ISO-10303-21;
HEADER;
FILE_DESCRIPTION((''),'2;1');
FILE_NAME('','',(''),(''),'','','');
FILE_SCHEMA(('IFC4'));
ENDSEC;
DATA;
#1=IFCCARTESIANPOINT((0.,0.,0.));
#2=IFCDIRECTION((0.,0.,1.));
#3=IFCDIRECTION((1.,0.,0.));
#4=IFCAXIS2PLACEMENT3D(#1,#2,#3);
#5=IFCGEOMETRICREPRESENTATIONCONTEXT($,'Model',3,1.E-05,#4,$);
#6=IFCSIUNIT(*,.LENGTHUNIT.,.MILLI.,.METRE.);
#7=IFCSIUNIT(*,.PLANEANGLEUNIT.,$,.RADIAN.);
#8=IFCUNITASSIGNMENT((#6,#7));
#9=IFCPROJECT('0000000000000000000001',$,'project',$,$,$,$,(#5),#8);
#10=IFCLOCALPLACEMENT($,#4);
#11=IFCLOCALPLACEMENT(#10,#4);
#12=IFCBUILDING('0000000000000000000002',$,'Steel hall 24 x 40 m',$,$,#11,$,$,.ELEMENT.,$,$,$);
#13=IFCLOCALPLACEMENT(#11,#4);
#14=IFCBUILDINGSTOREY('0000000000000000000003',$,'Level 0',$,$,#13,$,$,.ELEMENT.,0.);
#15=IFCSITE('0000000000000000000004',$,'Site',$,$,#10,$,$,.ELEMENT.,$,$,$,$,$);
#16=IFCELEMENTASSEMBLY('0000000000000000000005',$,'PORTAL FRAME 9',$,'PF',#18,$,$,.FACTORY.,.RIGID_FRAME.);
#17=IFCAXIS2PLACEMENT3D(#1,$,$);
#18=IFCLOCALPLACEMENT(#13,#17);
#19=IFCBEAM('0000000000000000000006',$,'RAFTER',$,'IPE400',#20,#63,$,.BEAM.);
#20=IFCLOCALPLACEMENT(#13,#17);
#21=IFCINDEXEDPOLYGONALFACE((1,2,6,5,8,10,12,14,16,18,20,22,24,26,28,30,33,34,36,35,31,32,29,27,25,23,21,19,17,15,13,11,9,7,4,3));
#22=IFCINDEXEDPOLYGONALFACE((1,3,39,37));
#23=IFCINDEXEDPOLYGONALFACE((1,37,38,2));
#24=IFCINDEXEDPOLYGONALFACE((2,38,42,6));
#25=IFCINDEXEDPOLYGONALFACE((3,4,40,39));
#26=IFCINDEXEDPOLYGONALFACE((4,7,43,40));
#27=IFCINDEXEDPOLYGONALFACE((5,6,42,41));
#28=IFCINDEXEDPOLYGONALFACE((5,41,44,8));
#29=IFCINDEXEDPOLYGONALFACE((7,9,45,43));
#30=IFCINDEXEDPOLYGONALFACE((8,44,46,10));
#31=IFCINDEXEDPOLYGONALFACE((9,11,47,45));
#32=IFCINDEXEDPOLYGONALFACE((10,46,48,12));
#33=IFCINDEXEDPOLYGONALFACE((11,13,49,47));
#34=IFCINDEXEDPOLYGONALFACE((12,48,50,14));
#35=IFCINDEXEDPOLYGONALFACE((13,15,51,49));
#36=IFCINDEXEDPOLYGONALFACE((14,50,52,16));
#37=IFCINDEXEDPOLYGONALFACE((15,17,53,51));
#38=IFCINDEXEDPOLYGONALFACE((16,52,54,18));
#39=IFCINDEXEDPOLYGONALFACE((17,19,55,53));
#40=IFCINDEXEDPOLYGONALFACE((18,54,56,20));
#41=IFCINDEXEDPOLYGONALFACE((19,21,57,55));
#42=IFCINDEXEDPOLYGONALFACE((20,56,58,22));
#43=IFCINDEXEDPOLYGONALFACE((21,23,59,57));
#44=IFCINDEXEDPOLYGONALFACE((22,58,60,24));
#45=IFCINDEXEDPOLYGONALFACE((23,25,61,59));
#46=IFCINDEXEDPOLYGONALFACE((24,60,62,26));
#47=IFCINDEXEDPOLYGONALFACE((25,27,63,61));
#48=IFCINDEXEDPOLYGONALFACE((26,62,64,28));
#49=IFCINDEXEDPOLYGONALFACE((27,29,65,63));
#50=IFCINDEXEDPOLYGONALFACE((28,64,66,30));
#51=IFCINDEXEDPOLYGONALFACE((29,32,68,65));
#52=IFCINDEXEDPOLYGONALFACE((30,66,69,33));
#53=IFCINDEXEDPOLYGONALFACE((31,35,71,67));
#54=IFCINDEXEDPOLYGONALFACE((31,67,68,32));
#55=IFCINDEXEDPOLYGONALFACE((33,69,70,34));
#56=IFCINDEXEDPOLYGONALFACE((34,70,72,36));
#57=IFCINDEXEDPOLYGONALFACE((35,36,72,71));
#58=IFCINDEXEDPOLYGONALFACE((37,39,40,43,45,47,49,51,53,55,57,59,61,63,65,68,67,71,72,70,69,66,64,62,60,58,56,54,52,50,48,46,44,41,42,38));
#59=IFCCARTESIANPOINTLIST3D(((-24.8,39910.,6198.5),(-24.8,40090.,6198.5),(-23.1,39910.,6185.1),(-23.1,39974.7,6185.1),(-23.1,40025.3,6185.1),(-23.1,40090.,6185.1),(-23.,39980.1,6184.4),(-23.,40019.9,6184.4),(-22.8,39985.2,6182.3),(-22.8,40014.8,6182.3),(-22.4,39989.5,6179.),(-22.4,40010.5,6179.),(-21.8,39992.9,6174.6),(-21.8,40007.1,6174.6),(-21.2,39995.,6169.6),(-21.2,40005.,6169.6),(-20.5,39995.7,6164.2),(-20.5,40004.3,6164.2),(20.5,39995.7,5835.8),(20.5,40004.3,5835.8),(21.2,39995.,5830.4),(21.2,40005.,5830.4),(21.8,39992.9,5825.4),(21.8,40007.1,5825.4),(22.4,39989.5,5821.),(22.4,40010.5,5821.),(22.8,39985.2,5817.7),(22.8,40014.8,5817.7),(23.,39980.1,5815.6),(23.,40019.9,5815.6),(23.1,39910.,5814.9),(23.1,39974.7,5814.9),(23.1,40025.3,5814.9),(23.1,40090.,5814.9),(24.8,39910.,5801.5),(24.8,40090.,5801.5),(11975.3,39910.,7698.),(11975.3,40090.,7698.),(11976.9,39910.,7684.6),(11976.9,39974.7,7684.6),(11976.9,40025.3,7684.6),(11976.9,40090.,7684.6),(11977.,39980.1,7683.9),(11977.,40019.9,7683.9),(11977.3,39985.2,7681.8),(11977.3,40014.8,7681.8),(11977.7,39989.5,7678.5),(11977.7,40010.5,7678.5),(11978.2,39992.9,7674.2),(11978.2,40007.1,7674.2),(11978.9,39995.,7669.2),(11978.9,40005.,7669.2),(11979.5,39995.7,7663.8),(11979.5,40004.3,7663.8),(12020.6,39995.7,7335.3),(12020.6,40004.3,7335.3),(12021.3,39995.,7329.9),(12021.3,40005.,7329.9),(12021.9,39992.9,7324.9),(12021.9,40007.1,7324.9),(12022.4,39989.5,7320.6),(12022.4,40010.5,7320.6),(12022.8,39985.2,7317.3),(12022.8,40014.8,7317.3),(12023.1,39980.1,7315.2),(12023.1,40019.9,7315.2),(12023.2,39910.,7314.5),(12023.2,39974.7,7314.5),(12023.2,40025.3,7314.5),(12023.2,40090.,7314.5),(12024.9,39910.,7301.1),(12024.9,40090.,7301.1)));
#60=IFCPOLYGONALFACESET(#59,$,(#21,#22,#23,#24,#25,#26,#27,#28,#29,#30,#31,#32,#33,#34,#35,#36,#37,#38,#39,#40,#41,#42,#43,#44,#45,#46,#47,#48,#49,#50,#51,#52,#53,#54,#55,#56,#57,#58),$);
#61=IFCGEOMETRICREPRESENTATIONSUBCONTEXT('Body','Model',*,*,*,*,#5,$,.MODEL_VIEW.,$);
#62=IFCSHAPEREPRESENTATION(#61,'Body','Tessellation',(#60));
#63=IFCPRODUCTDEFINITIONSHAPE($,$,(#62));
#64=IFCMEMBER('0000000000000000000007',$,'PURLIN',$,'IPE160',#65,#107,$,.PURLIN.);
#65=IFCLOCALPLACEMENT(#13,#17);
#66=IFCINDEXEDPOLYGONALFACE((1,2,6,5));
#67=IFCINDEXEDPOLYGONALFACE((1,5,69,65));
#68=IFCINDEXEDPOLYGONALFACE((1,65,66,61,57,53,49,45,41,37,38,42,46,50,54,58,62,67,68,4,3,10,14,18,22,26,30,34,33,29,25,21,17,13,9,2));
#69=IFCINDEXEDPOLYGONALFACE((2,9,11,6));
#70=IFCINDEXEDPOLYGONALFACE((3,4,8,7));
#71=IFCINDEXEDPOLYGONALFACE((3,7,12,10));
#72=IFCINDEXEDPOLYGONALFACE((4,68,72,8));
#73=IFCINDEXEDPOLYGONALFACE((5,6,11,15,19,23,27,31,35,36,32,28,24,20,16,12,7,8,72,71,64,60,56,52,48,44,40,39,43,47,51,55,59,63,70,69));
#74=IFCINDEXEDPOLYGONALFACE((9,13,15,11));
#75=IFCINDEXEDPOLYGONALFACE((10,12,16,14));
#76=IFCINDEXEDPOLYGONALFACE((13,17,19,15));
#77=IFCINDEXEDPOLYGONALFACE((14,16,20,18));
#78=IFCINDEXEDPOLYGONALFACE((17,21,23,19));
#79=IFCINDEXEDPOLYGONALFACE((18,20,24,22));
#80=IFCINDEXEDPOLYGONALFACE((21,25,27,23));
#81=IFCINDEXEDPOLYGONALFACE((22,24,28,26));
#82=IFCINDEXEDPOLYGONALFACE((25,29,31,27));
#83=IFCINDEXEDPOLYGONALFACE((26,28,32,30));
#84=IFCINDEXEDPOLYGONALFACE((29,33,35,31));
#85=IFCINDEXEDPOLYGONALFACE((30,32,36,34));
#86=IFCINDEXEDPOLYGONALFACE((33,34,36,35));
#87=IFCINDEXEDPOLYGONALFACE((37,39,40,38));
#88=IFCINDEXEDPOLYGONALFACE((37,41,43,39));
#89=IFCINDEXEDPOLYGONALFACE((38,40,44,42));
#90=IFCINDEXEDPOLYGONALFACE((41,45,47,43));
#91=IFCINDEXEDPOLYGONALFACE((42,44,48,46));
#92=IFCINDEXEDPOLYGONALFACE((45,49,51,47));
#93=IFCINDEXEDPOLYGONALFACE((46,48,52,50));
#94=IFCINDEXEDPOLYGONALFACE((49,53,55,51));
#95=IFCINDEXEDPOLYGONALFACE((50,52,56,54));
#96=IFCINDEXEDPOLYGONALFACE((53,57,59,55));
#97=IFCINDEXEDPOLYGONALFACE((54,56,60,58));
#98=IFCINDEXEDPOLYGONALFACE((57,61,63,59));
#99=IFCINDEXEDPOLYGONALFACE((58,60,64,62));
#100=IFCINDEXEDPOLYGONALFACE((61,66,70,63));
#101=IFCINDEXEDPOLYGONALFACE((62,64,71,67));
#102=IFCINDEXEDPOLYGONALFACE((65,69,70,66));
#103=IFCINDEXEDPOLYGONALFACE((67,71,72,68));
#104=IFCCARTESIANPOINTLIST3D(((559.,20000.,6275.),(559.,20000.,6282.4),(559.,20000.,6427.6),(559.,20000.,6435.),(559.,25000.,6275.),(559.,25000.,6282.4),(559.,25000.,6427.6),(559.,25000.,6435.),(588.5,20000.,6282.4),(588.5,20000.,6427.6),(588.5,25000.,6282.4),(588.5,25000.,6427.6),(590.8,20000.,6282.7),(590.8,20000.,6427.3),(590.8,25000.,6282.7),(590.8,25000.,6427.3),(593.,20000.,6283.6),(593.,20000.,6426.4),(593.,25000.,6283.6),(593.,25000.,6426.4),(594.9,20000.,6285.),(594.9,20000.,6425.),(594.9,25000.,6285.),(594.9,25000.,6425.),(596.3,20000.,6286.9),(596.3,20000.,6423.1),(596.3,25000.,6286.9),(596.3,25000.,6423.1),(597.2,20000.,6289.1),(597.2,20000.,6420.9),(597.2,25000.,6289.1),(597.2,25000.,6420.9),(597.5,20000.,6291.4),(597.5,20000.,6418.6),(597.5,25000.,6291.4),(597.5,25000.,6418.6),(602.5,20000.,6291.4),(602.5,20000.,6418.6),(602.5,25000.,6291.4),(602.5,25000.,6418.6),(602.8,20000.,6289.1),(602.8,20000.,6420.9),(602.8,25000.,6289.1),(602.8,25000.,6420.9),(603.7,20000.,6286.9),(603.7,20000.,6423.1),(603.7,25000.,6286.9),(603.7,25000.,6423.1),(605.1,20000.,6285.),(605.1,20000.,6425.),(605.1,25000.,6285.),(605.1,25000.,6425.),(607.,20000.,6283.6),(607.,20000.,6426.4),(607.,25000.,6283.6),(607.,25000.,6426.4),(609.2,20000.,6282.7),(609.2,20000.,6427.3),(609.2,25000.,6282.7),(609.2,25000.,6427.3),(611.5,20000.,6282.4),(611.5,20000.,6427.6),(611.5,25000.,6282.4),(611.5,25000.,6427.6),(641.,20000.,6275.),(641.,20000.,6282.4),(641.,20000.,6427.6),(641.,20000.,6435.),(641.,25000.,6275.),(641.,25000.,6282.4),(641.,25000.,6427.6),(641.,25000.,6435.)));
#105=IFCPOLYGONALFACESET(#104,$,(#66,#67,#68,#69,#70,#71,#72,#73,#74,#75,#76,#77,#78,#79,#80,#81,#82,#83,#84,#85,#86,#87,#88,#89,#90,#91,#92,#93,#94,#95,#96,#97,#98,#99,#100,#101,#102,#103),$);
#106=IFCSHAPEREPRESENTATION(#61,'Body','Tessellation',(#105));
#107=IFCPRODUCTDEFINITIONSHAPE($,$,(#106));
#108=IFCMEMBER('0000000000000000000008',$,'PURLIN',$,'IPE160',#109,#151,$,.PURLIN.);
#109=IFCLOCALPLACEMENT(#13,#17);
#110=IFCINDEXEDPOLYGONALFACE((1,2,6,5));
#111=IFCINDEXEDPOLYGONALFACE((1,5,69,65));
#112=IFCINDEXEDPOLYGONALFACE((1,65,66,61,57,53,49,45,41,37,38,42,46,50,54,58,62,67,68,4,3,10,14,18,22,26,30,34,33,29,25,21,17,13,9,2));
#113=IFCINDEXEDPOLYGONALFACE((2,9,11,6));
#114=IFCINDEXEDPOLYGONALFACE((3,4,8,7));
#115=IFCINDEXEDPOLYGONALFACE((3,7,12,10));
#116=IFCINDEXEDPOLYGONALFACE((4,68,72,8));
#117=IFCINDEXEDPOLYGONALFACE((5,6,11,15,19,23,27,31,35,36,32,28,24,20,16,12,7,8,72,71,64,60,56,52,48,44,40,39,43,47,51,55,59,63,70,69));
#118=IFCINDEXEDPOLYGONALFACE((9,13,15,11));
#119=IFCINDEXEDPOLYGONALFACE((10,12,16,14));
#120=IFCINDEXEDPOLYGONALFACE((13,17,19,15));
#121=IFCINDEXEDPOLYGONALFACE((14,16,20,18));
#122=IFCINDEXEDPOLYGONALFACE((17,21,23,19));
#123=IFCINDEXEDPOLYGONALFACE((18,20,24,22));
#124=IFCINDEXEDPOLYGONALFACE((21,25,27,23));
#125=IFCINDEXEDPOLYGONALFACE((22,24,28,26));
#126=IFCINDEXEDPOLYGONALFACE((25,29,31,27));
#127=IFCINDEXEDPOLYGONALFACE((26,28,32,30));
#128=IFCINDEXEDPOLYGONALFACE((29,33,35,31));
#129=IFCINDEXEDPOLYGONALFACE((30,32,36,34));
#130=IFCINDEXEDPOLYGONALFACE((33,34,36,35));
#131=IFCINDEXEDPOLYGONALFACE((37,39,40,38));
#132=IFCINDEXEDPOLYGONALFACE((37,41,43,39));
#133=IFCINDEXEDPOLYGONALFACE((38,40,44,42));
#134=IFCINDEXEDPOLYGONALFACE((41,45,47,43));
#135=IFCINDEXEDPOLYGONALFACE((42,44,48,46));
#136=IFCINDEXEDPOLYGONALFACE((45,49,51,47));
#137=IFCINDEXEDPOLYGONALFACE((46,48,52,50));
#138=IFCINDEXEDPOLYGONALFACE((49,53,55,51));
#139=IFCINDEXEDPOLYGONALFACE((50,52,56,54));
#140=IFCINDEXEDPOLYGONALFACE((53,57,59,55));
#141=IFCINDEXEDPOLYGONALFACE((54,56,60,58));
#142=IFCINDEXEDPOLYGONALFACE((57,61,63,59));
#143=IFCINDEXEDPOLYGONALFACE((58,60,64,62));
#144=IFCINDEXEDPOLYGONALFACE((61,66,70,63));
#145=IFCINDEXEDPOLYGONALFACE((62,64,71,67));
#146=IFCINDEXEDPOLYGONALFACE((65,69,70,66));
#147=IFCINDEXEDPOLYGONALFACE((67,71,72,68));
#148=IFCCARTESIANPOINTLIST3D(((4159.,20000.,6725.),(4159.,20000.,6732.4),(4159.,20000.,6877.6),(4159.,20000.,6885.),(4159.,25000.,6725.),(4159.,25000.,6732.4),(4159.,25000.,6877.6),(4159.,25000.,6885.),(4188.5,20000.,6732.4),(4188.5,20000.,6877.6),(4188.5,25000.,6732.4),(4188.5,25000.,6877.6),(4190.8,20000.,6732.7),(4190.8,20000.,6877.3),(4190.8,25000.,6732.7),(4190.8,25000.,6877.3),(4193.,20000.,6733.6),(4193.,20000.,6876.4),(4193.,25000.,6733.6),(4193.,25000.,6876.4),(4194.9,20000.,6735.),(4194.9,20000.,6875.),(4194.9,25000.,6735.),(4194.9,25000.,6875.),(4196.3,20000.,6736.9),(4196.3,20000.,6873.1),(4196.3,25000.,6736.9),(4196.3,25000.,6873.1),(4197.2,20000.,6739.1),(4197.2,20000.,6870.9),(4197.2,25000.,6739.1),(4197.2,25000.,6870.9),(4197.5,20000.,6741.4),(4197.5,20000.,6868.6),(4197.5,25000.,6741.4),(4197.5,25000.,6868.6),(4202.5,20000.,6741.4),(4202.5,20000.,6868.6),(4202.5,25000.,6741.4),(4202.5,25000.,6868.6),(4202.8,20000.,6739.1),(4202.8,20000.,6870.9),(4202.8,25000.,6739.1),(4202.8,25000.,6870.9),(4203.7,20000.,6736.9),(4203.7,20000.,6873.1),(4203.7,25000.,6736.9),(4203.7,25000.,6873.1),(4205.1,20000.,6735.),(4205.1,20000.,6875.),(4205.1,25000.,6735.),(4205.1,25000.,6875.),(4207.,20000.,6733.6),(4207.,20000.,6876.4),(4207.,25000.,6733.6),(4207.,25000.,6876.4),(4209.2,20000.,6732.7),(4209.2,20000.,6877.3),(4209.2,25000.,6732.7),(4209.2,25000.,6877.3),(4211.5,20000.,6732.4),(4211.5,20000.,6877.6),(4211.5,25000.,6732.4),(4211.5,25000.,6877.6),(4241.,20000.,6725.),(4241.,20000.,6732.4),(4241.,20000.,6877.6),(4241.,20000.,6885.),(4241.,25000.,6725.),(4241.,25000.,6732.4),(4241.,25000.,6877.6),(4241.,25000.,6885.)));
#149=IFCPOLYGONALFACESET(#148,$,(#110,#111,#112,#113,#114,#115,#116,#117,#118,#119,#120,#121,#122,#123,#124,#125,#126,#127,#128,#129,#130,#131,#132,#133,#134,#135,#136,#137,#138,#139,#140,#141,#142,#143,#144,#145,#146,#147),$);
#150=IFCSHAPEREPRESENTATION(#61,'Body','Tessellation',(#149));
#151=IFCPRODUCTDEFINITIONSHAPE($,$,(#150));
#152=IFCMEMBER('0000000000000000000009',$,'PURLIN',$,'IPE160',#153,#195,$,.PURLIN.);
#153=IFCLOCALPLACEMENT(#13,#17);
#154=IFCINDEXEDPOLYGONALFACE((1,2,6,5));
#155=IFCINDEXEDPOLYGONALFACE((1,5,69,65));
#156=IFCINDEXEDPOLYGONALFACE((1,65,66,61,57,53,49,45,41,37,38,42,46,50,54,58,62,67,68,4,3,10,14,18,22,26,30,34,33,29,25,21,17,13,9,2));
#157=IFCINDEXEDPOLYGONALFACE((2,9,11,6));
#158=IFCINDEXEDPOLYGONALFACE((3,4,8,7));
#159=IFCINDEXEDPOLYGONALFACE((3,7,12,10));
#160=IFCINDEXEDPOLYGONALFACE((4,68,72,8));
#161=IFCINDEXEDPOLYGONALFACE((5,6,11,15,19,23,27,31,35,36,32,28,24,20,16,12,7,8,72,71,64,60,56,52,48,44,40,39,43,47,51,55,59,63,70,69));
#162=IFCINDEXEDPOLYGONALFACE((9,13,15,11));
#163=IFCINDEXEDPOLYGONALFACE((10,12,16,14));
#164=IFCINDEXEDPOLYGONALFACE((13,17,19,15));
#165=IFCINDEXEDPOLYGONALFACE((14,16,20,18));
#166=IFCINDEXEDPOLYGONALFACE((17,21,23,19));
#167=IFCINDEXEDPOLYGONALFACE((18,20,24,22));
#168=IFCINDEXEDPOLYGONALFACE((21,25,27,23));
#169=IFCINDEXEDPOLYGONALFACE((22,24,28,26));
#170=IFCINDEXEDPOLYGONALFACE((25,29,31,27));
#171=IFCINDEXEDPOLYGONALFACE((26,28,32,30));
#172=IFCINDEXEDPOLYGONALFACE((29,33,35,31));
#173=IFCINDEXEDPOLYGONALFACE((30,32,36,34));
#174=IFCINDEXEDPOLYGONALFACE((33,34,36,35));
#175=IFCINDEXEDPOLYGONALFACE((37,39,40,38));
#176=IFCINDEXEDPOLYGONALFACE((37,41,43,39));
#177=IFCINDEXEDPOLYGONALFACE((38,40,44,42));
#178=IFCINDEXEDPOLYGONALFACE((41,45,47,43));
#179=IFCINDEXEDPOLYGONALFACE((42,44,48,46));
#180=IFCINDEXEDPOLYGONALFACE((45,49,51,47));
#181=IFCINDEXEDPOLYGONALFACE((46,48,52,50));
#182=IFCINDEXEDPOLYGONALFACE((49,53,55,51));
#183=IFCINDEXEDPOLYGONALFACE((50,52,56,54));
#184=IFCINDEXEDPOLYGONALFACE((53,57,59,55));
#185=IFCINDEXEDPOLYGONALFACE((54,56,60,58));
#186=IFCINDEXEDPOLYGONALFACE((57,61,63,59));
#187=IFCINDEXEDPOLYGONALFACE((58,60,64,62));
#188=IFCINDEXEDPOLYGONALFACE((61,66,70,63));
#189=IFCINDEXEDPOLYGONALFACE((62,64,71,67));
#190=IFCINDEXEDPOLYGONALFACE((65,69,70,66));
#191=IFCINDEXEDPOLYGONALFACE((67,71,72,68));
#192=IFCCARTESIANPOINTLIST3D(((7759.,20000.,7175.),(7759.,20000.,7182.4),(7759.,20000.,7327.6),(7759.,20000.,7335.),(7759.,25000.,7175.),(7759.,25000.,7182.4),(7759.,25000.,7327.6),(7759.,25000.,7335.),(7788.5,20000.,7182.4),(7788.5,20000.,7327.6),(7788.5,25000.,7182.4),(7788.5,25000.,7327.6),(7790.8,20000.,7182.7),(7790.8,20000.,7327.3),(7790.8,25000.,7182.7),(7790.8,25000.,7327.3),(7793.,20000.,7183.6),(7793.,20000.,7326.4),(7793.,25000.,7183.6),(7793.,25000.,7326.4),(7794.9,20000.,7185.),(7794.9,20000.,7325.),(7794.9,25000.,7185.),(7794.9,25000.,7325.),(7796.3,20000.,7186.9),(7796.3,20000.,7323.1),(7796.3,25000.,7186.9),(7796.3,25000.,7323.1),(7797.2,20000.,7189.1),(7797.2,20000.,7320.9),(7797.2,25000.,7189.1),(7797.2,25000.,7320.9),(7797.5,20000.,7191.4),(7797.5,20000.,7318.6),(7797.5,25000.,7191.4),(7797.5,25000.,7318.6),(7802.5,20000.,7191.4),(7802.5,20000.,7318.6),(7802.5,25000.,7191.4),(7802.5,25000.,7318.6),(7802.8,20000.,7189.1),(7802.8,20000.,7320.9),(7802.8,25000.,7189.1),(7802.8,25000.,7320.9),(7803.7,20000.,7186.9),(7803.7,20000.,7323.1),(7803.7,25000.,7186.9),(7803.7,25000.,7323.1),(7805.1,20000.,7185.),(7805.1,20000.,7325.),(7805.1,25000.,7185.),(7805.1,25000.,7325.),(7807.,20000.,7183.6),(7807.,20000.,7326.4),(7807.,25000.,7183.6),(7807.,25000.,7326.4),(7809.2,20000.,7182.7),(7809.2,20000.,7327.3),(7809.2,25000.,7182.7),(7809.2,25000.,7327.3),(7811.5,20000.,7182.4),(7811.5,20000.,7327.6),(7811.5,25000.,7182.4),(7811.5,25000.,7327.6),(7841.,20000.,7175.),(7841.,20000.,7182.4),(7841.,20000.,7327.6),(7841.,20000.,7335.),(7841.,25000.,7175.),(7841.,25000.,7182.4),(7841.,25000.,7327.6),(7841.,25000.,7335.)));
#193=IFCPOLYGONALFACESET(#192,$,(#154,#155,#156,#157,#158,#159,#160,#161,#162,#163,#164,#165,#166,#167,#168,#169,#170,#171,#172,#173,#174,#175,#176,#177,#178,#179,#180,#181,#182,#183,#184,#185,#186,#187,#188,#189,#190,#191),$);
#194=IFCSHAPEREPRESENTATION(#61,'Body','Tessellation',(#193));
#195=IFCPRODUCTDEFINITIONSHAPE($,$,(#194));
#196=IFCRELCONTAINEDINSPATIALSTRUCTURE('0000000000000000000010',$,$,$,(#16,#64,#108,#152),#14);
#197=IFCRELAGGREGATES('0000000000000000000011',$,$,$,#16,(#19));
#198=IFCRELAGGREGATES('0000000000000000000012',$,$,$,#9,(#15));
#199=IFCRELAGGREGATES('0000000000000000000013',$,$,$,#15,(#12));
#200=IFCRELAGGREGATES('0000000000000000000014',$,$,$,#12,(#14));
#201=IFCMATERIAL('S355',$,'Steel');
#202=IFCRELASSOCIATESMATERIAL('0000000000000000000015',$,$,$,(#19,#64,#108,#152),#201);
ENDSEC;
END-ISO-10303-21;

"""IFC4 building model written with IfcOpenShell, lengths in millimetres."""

from ifc_helpers import new_model, si_unit, frame, origin_with_axes, place, context, subcontext, project, spatial, i_section, extrude, material, element, aggregate, save


model = new_model("IFC4")

# Units and contexts
model_context = context("Model", 3, precision=1e-05, world=origin_with_axes())
body_context = subcontext(model_context, "Body", "Model", "MODEL_VIEW")
ifc_project = project(units=[si_unit("LENGTHUNIT", "METRE", prefix="MILLI"), si_unit("PLANEANGLEUNIT", "RADIAN")], contexts=[model_context])

# Site, building, storey
site_placement = place(None, origin_with_axes())
site = spatial("IfcSite", under=ifc_project, at=site_placement, Name="Site", CompositionType="ELEMENT")
building_placement = place(site_placement, origin_with_axes())
building = spatial("IfcBuilding", under=site, at=building_placement, Name="Steel hall 24 x 40 m", CompositionType="ELEMENT")
storey_placement = place(building_placement, origin_with_axes())
storey = spatial("IfcBuildingStorey", under=building, at=storey_placement, Name="Level 0", CompositionType="ELEMENT", Elevation=0.0)

# Element assembly
ifc_material = material(Name="S355", Category="Steel")
assembly_1_placement = place(storey_placement, frame((0.0, 40000.0, 0.0), z_axis=(0.0, 0.0, 1.0), x_axis=(1.0, 0.0, 0.0)))
assembly_1 = element("IfcElementAssembly", 1, at=assembly_1_placement, inside=storey, Name="PORTAL FRAME 9", ObjectType="PF", AssemblyPlace="FACTORY", PredefinedType="RIGID_FRAME")

# Beam
beam_1_placement = place(storey_placement, frame((0.0, 40000.0, 6000.0), z_axis=(0.9923, 0.0, 0.124), x_axis=(0.0, 1.0, 0.0)))
beam_1 = element("IfcBeam", 2, at=beam_1_placement, material=ifc_material, Name="RAFTER", ObjectType="IPE400", PredefinedType="BEAM", context=body_context, shape_type="SweptSolid", body=[
    extrude(i_section(OverallWidth=180.0, OverallDepth=400.0, WebThickness=8.6, FlangeThickness=13.5, FilletRadius=21.0), origin_with_axes(), (0.0, 0.0, 1.0), 12093.4),
])

# Members
for number, where, z_axis, x_axis, name in (
    (3, (600.0, 20000.0, 6355.0), (0.0, 1.0, 0.0), (1.0, 0.0, 0.0), "PURLIN"),
    (4, (4200.0, 20000.0, 6805.0), (0.0, 1.0, 0.0), (1.0, 0.0, 0.0), "PURLIN"),
    (5, (7800.0, 20000.0, 7255.0), (0.0, 1.0, 0.0), (1.0, 0.0, 0.0), "PURLIN"),
):
    element("IfcMember", number, at=place(storey_placement, frame(where, z_axis=z_axis, x_axis=x_axis)), inside=storey, material=ifc_material, Name=name, ObjectType="IPE160", PredefinedType="PURLIN", context=body_context, shape_type="SweptSolid", body=[
        extrude(i_section(OverallWidth=82.0, OverallDepth=160.0, WebThickness=5.0, FlangeThickness=7.4, FilletRadius=9.0), origin_with_axes(), (0.0, 0.0, 1.0), 5000.0),
    ])

aggregate(assembly_1, [beam_1])

save(model, "model.ifc")
